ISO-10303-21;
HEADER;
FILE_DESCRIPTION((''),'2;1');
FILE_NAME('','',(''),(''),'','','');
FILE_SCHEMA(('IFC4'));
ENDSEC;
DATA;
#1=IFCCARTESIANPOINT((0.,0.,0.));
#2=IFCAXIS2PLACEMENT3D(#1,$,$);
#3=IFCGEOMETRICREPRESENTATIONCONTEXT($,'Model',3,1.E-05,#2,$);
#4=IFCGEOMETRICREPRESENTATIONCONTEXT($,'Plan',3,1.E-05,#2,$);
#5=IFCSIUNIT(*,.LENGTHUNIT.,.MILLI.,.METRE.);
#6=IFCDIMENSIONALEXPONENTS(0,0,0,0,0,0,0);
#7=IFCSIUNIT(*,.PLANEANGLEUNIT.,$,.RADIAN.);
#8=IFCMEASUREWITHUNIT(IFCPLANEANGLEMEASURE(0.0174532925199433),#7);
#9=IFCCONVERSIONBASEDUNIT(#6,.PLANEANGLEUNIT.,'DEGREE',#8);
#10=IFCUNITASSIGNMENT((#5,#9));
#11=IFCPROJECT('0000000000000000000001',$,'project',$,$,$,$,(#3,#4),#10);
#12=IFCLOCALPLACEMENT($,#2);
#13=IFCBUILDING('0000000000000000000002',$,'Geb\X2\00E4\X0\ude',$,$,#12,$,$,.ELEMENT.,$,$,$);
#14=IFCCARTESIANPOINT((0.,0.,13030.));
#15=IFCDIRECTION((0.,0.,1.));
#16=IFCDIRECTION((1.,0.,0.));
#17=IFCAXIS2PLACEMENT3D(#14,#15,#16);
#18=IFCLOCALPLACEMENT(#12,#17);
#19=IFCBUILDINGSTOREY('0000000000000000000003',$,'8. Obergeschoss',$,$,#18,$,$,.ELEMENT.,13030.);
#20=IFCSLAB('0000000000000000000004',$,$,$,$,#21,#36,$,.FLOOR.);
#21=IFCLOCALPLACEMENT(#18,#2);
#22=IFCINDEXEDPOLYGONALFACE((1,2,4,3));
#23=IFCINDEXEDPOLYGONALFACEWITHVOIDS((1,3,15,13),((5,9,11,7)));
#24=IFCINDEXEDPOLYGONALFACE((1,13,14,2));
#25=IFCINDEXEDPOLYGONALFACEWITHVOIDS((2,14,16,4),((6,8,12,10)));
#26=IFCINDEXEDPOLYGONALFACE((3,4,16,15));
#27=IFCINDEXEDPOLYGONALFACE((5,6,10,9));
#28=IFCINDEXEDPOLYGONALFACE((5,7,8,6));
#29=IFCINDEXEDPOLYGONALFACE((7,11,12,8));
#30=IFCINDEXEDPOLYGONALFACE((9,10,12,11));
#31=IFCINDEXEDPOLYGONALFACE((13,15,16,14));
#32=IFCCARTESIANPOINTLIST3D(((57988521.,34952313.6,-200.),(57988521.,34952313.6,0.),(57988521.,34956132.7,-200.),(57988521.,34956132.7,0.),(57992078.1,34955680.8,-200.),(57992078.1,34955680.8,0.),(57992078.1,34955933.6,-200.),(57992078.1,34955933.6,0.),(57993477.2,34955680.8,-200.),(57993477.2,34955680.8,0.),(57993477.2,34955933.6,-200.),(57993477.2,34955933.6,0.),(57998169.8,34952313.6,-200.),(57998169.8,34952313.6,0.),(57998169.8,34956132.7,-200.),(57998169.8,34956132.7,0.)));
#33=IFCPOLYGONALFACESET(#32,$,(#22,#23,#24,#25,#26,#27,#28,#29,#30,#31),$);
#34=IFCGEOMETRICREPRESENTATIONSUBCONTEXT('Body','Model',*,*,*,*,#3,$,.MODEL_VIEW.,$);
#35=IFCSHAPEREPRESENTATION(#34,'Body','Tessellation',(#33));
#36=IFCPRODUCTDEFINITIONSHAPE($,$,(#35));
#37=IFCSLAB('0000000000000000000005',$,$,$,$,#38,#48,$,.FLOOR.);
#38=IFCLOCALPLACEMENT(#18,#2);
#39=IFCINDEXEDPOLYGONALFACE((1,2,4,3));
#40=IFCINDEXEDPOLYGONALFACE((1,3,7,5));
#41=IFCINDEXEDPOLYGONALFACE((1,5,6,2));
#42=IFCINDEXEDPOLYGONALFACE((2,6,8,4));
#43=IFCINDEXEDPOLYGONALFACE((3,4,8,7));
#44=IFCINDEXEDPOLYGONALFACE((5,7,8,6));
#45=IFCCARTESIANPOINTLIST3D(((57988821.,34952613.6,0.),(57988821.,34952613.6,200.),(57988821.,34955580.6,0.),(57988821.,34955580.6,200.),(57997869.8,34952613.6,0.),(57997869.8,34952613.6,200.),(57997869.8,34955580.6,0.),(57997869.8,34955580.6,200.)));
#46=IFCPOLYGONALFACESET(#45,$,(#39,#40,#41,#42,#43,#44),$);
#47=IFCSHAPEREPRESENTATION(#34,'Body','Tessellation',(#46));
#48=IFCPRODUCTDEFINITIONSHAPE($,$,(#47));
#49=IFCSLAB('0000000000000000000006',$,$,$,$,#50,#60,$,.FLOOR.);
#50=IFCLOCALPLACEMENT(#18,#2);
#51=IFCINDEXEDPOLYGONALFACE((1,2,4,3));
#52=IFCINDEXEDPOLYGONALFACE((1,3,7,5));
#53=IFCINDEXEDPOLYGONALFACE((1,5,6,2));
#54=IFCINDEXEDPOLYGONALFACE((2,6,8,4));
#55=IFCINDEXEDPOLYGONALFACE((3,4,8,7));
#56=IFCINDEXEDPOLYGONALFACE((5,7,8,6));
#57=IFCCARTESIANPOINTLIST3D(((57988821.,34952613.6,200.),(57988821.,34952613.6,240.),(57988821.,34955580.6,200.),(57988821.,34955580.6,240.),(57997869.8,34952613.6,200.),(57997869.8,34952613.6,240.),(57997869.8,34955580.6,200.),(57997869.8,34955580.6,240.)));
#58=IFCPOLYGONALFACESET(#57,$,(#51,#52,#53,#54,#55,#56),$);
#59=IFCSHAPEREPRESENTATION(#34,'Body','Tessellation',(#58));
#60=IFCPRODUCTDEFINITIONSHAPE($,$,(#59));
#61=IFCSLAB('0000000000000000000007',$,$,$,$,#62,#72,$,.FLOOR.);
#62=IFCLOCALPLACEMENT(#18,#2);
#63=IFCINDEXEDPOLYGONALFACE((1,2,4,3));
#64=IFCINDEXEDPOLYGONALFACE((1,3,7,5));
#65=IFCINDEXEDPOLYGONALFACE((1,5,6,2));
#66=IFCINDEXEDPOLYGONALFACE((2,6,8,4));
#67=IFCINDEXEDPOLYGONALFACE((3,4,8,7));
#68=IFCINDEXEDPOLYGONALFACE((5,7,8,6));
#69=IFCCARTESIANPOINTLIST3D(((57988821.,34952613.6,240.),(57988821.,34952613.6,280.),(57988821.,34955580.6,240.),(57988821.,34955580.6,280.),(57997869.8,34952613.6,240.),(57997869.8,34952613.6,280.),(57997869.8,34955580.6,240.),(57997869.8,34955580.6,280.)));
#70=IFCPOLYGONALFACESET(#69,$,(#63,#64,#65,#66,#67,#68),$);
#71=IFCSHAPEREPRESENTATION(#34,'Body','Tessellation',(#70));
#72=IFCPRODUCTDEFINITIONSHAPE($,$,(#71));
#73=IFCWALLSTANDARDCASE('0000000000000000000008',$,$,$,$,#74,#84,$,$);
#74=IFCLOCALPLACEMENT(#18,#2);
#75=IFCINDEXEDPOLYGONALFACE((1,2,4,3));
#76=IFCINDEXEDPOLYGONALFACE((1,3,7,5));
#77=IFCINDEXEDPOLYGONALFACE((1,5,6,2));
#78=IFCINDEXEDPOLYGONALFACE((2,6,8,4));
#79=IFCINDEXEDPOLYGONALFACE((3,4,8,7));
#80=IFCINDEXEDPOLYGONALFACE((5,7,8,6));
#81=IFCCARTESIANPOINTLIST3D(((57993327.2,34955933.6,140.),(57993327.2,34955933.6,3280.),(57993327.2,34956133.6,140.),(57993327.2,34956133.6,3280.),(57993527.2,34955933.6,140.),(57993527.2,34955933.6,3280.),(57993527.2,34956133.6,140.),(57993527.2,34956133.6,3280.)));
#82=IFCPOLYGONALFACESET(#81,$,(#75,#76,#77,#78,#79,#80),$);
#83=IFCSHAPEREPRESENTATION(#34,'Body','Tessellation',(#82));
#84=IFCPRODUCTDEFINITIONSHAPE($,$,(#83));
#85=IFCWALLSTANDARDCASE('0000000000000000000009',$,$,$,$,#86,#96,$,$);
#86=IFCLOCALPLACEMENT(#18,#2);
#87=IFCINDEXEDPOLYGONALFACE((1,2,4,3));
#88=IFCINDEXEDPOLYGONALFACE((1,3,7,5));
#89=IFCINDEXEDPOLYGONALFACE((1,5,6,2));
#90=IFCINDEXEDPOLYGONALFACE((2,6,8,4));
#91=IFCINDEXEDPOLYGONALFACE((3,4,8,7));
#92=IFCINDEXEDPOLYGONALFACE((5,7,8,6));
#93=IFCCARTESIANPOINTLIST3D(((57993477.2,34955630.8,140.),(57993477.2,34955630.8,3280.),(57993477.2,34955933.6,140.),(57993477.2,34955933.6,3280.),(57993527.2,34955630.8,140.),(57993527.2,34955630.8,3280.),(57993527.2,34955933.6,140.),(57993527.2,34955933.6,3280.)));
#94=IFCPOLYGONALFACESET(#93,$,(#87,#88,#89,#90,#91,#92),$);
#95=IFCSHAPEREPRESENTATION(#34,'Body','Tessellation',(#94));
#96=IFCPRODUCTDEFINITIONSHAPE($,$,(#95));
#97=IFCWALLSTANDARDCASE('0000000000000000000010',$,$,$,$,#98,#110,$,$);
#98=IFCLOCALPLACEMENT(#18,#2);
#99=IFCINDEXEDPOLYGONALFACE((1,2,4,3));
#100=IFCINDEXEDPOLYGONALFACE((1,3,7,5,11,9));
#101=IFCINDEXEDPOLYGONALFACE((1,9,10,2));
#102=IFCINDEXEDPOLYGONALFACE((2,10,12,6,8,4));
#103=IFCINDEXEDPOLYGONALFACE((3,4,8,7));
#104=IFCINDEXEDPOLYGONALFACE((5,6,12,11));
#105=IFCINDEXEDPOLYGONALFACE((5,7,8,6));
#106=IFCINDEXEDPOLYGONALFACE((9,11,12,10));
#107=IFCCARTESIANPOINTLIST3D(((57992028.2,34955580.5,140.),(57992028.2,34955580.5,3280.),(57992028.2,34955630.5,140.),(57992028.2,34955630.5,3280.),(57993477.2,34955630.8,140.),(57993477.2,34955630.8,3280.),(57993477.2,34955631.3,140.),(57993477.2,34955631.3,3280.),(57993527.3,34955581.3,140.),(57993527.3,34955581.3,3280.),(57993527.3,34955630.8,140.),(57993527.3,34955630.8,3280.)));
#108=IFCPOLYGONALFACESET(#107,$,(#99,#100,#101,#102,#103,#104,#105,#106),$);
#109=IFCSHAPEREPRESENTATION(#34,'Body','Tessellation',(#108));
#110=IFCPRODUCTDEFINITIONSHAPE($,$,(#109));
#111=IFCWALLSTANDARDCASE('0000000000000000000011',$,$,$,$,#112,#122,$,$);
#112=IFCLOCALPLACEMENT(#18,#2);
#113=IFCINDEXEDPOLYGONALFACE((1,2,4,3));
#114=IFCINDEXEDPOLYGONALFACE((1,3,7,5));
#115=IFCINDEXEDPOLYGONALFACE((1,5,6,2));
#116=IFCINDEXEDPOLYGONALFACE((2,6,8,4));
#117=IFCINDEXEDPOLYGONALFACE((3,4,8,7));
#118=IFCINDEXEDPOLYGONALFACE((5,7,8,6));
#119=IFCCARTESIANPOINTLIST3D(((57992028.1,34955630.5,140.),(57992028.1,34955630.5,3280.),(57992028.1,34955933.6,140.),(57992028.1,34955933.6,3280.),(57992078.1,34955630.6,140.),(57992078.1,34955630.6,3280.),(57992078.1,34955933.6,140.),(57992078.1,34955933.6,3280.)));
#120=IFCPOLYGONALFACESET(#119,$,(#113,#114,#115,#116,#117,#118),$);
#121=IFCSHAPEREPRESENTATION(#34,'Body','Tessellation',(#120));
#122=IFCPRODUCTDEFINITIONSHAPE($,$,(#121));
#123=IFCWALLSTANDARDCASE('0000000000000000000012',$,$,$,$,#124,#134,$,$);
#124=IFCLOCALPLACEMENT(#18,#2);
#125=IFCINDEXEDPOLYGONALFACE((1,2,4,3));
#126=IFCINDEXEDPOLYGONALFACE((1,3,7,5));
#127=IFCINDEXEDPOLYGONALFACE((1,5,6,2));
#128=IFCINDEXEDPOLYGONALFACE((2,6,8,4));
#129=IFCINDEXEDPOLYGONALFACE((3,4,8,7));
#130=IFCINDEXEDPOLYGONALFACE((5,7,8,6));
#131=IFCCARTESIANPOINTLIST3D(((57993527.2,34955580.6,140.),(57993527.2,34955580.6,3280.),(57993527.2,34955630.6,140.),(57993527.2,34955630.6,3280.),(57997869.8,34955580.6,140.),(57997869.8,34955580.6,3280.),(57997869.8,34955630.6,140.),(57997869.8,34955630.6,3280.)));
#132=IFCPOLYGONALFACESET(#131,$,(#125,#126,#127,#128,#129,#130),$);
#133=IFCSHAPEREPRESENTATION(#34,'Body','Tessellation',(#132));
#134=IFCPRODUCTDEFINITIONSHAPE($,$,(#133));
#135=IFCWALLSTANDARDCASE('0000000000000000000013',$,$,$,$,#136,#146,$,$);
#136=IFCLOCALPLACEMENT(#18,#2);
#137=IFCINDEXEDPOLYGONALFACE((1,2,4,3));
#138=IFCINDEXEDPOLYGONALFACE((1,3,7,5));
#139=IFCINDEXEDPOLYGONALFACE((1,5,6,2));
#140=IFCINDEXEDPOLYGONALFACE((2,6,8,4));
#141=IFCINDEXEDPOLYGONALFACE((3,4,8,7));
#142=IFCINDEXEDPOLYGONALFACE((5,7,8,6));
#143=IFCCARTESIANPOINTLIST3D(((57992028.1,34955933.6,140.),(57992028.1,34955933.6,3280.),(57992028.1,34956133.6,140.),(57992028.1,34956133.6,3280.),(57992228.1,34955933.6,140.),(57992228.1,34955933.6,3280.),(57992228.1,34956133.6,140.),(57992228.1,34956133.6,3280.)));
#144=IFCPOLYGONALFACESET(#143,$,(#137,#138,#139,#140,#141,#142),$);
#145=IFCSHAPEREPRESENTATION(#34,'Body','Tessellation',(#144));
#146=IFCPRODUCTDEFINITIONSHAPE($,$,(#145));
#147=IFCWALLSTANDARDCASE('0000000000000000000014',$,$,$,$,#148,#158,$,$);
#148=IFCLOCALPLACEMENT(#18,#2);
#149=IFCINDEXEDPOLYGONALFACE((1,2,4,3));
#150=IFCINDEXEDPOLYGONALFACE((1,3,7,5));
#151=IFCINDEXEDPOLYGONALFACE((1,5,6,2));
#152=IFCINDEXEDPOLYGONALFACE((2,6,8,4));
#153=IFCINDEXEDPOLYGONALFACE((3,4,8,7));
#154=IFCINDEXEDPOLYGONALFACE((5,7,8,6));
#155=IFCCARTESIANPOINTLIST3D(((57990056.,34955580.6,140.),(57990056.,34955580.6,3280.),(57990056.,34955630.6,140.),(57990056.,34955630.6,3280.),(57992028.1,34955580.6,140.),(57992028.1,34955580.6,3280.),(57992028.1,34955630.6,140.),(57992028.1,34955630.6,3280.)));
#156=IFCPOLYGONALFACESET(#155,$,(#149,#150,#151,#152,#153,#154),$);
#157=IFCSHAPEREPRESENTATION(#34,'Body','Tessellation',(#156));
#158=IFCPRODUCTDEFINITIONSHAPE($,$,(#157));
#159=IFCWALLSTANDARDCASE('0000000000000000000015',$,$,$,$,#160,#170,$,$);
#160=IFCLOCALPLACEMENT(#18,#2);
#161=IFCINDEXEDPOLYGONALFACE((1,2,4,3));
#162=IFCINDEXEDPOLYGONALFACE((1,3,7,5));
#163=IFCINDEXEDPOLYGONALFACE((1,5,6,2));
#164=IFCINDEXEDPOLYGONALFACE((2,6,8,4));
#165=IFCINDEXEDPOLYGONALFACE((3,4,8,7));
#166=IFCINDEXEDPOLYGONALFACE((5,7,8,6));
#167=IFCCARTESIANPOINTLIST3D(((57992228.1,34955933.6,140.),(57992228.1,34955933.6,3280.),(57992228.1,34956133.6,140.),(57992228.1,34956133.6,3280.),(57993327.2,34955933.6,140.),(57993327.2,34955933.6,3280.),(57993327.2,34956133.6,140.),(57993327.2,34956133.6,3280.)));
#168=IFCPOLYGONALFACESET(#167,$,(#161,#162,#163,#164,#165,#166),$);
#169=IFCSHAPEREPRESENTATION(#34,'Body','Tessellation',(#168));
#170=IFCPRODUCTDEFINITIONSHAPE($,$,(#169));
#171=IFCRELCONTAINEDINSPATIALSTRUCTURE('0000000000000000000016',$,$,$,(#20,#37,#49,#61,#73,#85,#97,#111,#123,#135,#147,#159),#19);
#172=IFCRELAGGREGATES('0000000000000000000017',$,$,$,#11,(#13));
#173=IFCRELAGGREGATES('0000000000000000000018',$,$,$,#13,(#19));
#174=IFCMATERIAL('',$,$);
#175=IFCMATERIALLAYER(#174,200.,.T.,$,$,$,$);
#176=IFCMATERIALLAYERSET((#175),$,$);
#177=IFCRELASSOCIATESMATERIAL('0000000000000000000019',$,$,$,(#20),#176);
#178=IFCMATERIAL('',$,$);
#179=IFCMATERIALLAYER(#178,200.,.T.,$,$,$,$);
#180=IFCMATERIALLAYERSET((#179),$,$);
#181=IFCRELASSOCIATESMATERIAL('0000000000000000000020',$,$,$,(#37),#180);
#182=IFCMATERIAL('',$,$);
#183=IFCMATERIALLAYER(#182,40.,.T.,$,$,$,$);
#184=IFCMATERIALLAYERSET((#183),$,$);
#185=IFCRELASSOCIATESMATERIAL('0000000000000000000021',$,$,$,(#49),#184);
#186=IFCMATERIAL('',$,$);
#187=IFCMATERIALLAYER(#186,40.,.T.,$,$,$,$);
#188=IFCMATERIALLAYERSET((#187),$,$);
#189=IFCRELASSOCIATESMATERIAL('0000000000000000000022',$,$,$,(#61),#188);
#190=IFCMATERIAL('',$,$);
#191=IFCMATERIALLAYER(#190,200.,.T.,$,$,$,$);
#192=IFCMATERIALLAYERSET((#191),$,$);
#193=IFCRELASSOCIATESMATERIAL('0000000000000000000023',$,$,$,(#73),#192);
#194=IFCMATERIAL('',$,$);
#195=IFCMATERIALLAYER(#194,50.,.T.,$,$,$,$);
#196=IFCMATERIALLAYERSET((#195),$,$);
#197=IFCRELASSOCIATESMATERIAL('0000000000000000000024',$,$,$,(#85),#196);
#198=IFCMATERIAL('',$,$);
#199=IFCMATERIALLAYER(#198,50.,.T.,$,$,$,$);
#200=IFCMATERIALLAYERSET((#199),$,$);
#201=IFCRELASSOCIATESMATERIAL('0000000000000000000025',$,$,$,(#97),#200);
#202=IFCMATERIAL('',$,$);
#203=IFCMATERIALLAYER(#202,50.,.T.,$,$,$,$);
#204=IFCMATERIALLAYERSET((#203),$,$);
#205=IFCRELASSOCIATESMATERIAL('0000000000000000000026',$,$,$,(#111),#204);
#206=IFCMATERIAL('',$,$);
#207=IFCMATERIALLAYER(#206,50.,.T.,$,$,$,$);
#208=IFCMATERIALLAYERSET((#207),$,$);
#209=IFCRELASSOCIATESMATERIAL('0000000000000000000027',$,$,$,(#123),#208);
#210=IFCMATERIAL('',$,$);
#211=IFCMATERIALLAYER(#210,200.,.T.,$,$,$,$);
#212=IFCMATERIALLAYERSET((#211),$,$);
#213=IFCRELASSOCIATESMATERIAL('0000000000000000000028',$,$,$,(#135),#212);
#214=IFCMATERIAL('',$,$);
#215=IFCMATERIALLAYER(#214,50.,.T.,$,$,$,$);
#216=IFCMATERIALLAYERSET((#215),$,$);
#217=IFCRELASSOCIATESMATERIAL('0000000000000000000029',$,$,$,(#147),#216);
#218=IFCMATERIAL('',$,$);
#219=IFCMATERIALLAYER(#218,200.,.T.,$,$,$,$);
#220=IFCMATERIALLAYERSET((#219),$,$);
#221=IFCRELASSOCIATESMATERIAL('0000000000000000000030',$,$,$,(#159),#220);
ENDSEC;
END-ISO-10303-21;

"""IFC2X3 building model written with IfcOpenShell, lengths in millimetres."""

from ifc_helpers import new_model, entity, si_unit, converted_unit, frame, frame_2d, origin, origin_with_axes, place, context, subcontext, project, spatial, polyline, rectangle, outline, extrude, material, layer, layer_set, layer_usage, element, save


model = new_model("IFC2X3")

# Units and contexts
model_context = context("Model", 3, precision=1e-05, world=origin())
plan_context = context("Plan", 3, precision=1e-05, world=origin())
body_context = subcontext(model_context, "Body", "Model", "MODEL_VIEW")
ifc_project = project(units=[si_unit("LENGTHUNIT", "METRE", prefix="MILLI"), converted_unit("PLANEANGLEUNIT", "DEGREE", entity("IfcPlaneAngleMeasure", 0.0174532925199433), si_unit("PLANEANGLEUNIT", "RADIAN"), dimensions=[0, 0, 0, 0, 0, 0, 0])], contexts=[model_context, plan_context])

# Building, storey
building_placement = place(None, origin())
building = spatial("IfcBuilding", under=ifc_project, at=building_placement, Name="Gebäude", CompositionType="ELEMENT")
storey_placement = place(building_placement, frame((0.0, 0.0, 13030.0), z_axis=(0.0, 0.0, 1.0), x_axis=(1.0, 0.0, 0.0)))
storey = spatial("IfcBuildingStorey", under=building, at=storey_placement, Name="8. Obergeschoss", CompositionType="ELEMENT", Elevation=13030.0)

# Slab, opening
ifc_material_1 = material(Name="")
ifc_layer_1 = layer(ifc_material_1, 200.0, ventilated=True)
ifc_layer_set_1 = layer_set([ifc_layer_1])
ifc_layer_usage_1 = layer_usage(ifc_layer_set_1, "AXIS3", "POSITIVE", 0.0)
slab_1_placement = place(storey_placement, frame((57988521.0, 34952313.6, -200.0), z_axis=(0.0, 0.0, 1.0), x_axis=(1.0, 0.0, 0.0)))
slab_1 = element("IfcSlab", 1, at=slab_1_placement, inside=storey, material=ifc_layer_usage_1, PredefinedType="FLOOR", context=body_context, shape_type="SweptSolid", body=[
    extrude(rectangle(XDim=9648.8, YDim=3819.0, at=frame_2d((4824.4, 1909.5), x_axis=(1.0, 0.0))), origin_with_axes(), (0.0, 0.0, 1.0), 200.0),
])
opening_placement = place(slab_1_placement, frame((3557.1, 3367.2, 0.0), z_axis=(0.0, 0.0, 1.0), x_axis=(1.0, 0.0, 0.0)))
element("IfcOpeningElement", 2, at=opening_placement, cuts=slab_1, ObjectType="Opening", context=body_context, shape_type="SweptSolid", body=[
    extrude(outline(polyline([(0.0, 252.8), (0.0, 0.0), (1399.1, 0.0), (1399.1, 252.8), (0.0, 252.8)])), origin_with_axes(), (0.0, 0.0, 1.0), 200.0),
])

# Slabs
ifc_material_2 = material(Name="")
ifc_layer_2 = layer(ifc_material_2, 200.0, ventilated=True)
ifc_layer_set_2 = layer_set([ifc_layer_2])
ifc_layer_usage_2 = layer_usage(ifc_layer_set_2, "AXIS3", "POSITIVE", 0.0)
slab_2_placement = place(storey_placement, frame((57988821.0, 34955580.6, 0.0), z_axis=(0.0, 0.0, 1.0), x_axis=(1.0, 0.0, 0.0)))
element("IfcSlab", 3, at=slab_2_placement, inside=storey, material=ifc_layer_usage_2, PredefinedType="FLOOR", context=body_context, shape_type="SweptSolid", body=[
    extrude(rectangle(XDim=2966.9, YDim=9048.8, at=frame_2d((4524.4, -1483.5), x_axis=(0.0, -1.0))), origin_with_axes(), (0.0, 0.0, 1.0), 200.0),
])
ifc_material_3 = material(Name="")
ifc_layer_3 = layer(ifc_material_3, 40.0, ventilated=True)
ifc_layer_set_3 = layer_set([ifc_layer_3])
ifc_layer_usage_3 = layer_usage(ifc_layer_set_3, "AXIS3", "POSITIVE", 0.0)
slab_3_placement = place(storey_placement, frame((57988821.0, 34955580.6, 200.0), z_axis=(0.0, 0.0, 1.0), x_axis=(1.0, 0.0, 0.0)))
element("IfcSlab", 4, at=slab_3_placement, inside=storey, material=ifc_layer_usage_3, PredefinedType="FLOOR", context=body_context, shape_type="SweptSolid", body=[
    extrude(rectangle(XDim=2966.9, YDim=9048.8, at=frame_2d((4524.4, -1483.5), x_axis=(0.0, -1.0))), origin_with_axes(), (0.0, 0.0, 1.0), 40.0),
])
ifc_material_4 = material(Name="")
ifc_layer_4 = layer(ifc_material_4, 40.0, ventilated=True)
ifc_layer_set_4 = layer_set([ifc_layer_4])
ifc_layer_usage_4 = layer_usage(ifc_layer_set_4, "AXIS3", "POSITIVE", 0.0)
slab_4_placement = place(storey_placement, frame((57988821.0, 34955580.6, 240.0), z_axis=(0.0, 0.0, 1.0), x_axis=(1.0, 0.0, 0.0)))
element("IfcSlab", 5, at=slab_4_placement, inside=storey, material=ifc_layer_usage_4, PredefinedType="FLOOR", context=body_context, shape_type="SweptSolid", body=[
    extrude(rectangle(XDim=2966.9, YDim=9048.8, at=frame_2d((4524.4, -1483.5), x_axis=(0.0, -1.0))), origin_with_axes(), (0.0, 0.0, 1.0), 40.0),
])

# Walls
ifc_material_5 = material(Name="")
ifc_layer_5 = layer(ifc_material_5, 200.0, ventilated=True)
ifc_layer_set_5 = layer_set([ifc_layer_5])
ifc_layer_usage_5 = layer_usage(ifc_layer_set_5, "AXIS2", "POSITIVE", 0.0)
wall_1_placement = place(storey_placement, frame((57993327.2, 34956133.6, 140.0), z_axis=(0.0, 0.0, 1.0), x_axis=(0.0, -1.0, 0.0)))
element("IfcWallStandardCase", 6, at=wall_1_placement, inside=storey, material=ifc_layer_usage_5, context=body_context, shape_type="SweptSolid", body=[
    extrude(rectangle(XDim=200.0, YDim=200.0, at=frame_2d((100.0, 100.0), x_axis=(1.0, 0.0))), origin_with_axes(), (0.0, 0.0, 1.0), 3140.0),
])
ifc_material_6 = material(Name="")
ifc_layer_6 = layer(ifc_material_6, 50.0, ventilated=True)
ifc_layer_set_6 = layer_set([ifc_layer_6])
ifc_layer_usage_6 = layer_usage(ifc_layer_set_6, "AXIS2", "POSITIVE", 0.0)
wall_2_placement = place(storey_placement, frame((57993527.2, 34955630.8, 140.0), z_axis=(0.0, 0.0, 1.0), x_axis=(0.0, 1.0, 0.0)))
element("IfcWallStandardCase", 7, at=wall_2_placement, inside=storey, material=ifc_layer_usage_6, context=body_context, shape_type="SweptSolid", body=[
    extrude(rectangle(XDim=302.8, YDim=50.0, at=frame_2d((151.4, 25.0), x_axis=(1.0, 0.0))), origin_with_axes(), (0.0, 0.0, 1.0), 3140.0),
])
ifc_material_7 = material(Name="")
ifc_layer_7 = layer(ifc_material_7, 50.0, ventilated=True)
ifc_layer_set_7 = layer_set([ifc_layer_7])
ifc_layer_usage_7 = layer_usage(ifc_layer_set_7, "AXIS2", "POSITIVE", 0.0)
wall_3_placement = place(storey_placement, frame((57992028.2, 34955580.5, 140.0), z_axis=(0.0, 0.0, 1.0), x_axis=(1.0, 0.000517, 0.0)))
element("IfcWallStandardCase", 8, at=wall_3_placement, inside=storey, material=ifc_layer_usage_7, context=body_context, shape_type="SweptSolid", body=[
    extrude(outline(polyline([(0.0, 0.0), (1499.1, 0.0), (1499.1, 50.0), (1499.1, 49.5), (1449.1, 49.6), (1449.1, 50.0), (0.0, 50.0), (0.0, 0.0)])), origin_with_axes(), (0.0, 0.0, 1.0), 3140.0),
])
ifc_material_8 = material(Name="")
ifc_layer_8 = layer(ifc_material_8, 50.0, ventilated=True)
ifc_layer_set_8 = layer_set([ifc_layer_8])
ifc_layer_usage_8 = layer_usage(ifc_layer_set_8, "AXIS2", "POSITIVE", 0.0)
wall_4_placement = place(storey_placement, frame((57992028.1, 34955933.6, 140.0), z_axis=(0.0, 0.0, 1.0), x_axis=(0.0, -1.0, 0.0)))
element("IfcWallStandardCase", 9, at=wall_4_placement, inside=storey, material=ifc_layer_usage_8, context=body_context, shape_type="SweptSolid", body=[
    extrude(outline(polyline([(0.0, 0.0), (303.5, 0.0), (303.1, 0.0), (303.0, 50.0), (0.0, 50.0), (0.0, 0.0)])), origin_with_axes(), (0.0, 0.0, 1.0), 3140.0),
])
ifc_material_9 = material(Name="")
ifc_layer_9 = layer(ifc_material_9, 50.0, ventilated=True)
ifc_layer_set_9 = layer_set([ifc_layer_9])
ifc_layer_usage_9 = layer_usage(ifc_layer_set_9, "AXIS2", "POSITIVE", 0.0)
wall_5_placement = place(storey_placement, frame((57993527.2, 34955580.6, 140.0), z_axis=(0.0, 0.0, 1.0), x_axis=(1.0, 0.0, 0.0)))
element("IfcWallStandardCase", 10, at=wall_5_placement, inside=storey, material=ifc_layer_usage_9, context=body_context, shape_type="SweptSolid", body=[
    extrude(rectangle(XDim=4342.6, YDim=50.0, at=frame_2d((2171.3, 25.0), x_axis=(1.0, 0.0))), origin_with_axes(), (0.0, 0.0, 1.0), 3140.0),
])
ifc_material_10 = material(Name="")
ifc_layer_10 = layer(ifc_material_10, 200.0, ventilated=True)
ifc_layer_set_10 = layer_set([ifc_layer_10])
ifc_layer_usage_10 = layer_usage(ifc_layer_set_10, "AXIS2", "POSITIVE", 0.0)
wall_6_placement = place(storey_placement, frame((57992028.1, 34956133.6, 140.0), z_axis=(0.0, 0.0, 1.0), x_axis=(0.0, -1.0, 0.0)))
element("IfcWallStandardCase", 11, at=wall_6_placement, inside=storey, material=ifc_layer_usage_10, context=body_context, shape_type="SweptSolid", body=[
    extrude(rectangle(XDim=200.0, YDim=200.0, at=frame_2d((100.0, 100.0), x_axis=(1.0, 0.0))), origin_with_axes(), (0.0, 0.0, 1.0), 3140.0),
])
ifc_material_11 = material(Name="")
ifc_layer_11 = layer(ifc_material_11, 50.0, ventilated=True)
ifc_layer_set_11 = layer_set([ifc_layer_11])
ifc_layer_usage_11 = layer_usage(ifc_layer_set_11, "AXIS2", "POSITIVE", 0.0)
wall_7_placement = place(storey_placement, frame((57990056.0, 34955580.6, 140.0), z_axis=(0.0, 0.0, 1.0), x_axis=(1.0, 0.0, 0.0)))
element("IfcWallStandardCase", 12, at=wall_7_placement, inside=storey, material=ifc_layer_usage_11, context=body_context, shape_type="SweptSolid", body=[
    extrude(rectangle(XDim=1972.1, YDim=50.0, at=frame_2d((986.0, 25.0), x_axis=(1.0, 0.0))), origin_with_axes(), (0.0, 0.0, 1.0), 3140.0),
])
ifc_material_12 = material(Name="")
ifc_layer_12 = layer(ifc_material_12, 200.0, ventilated=True)
ifc_layer_set_12 = layer_set([ifc_layer_12])
ifc_layer_usage_12 = layer_usage(ifc_layer_set_12, "AXIS2", "POSITIVE", 0.0)
wall_8_placement = place(storey_placement, frame((57992228.1, 34955933.6, 140.0), z_axis=(0.0, 0.0, 1.0), x_axis=(1.0, 0.0, 0.0)))
element("IfcWallStandardCase", 13, at=wall_8_placement, inside=storey, material=ifc_layer_usage_12, context=body_context, shape_type="SweptSolid", body=[
    extrude(rectangle(XDim=1099.1, YDim=200.0, at=frame_2d((549.6, 100.0), x_axis=(1.0, 0.0))), origin_with_axes(), (0.0, 0.0, 1.0), 3140.0),
])

save(model, "model.ifc")
